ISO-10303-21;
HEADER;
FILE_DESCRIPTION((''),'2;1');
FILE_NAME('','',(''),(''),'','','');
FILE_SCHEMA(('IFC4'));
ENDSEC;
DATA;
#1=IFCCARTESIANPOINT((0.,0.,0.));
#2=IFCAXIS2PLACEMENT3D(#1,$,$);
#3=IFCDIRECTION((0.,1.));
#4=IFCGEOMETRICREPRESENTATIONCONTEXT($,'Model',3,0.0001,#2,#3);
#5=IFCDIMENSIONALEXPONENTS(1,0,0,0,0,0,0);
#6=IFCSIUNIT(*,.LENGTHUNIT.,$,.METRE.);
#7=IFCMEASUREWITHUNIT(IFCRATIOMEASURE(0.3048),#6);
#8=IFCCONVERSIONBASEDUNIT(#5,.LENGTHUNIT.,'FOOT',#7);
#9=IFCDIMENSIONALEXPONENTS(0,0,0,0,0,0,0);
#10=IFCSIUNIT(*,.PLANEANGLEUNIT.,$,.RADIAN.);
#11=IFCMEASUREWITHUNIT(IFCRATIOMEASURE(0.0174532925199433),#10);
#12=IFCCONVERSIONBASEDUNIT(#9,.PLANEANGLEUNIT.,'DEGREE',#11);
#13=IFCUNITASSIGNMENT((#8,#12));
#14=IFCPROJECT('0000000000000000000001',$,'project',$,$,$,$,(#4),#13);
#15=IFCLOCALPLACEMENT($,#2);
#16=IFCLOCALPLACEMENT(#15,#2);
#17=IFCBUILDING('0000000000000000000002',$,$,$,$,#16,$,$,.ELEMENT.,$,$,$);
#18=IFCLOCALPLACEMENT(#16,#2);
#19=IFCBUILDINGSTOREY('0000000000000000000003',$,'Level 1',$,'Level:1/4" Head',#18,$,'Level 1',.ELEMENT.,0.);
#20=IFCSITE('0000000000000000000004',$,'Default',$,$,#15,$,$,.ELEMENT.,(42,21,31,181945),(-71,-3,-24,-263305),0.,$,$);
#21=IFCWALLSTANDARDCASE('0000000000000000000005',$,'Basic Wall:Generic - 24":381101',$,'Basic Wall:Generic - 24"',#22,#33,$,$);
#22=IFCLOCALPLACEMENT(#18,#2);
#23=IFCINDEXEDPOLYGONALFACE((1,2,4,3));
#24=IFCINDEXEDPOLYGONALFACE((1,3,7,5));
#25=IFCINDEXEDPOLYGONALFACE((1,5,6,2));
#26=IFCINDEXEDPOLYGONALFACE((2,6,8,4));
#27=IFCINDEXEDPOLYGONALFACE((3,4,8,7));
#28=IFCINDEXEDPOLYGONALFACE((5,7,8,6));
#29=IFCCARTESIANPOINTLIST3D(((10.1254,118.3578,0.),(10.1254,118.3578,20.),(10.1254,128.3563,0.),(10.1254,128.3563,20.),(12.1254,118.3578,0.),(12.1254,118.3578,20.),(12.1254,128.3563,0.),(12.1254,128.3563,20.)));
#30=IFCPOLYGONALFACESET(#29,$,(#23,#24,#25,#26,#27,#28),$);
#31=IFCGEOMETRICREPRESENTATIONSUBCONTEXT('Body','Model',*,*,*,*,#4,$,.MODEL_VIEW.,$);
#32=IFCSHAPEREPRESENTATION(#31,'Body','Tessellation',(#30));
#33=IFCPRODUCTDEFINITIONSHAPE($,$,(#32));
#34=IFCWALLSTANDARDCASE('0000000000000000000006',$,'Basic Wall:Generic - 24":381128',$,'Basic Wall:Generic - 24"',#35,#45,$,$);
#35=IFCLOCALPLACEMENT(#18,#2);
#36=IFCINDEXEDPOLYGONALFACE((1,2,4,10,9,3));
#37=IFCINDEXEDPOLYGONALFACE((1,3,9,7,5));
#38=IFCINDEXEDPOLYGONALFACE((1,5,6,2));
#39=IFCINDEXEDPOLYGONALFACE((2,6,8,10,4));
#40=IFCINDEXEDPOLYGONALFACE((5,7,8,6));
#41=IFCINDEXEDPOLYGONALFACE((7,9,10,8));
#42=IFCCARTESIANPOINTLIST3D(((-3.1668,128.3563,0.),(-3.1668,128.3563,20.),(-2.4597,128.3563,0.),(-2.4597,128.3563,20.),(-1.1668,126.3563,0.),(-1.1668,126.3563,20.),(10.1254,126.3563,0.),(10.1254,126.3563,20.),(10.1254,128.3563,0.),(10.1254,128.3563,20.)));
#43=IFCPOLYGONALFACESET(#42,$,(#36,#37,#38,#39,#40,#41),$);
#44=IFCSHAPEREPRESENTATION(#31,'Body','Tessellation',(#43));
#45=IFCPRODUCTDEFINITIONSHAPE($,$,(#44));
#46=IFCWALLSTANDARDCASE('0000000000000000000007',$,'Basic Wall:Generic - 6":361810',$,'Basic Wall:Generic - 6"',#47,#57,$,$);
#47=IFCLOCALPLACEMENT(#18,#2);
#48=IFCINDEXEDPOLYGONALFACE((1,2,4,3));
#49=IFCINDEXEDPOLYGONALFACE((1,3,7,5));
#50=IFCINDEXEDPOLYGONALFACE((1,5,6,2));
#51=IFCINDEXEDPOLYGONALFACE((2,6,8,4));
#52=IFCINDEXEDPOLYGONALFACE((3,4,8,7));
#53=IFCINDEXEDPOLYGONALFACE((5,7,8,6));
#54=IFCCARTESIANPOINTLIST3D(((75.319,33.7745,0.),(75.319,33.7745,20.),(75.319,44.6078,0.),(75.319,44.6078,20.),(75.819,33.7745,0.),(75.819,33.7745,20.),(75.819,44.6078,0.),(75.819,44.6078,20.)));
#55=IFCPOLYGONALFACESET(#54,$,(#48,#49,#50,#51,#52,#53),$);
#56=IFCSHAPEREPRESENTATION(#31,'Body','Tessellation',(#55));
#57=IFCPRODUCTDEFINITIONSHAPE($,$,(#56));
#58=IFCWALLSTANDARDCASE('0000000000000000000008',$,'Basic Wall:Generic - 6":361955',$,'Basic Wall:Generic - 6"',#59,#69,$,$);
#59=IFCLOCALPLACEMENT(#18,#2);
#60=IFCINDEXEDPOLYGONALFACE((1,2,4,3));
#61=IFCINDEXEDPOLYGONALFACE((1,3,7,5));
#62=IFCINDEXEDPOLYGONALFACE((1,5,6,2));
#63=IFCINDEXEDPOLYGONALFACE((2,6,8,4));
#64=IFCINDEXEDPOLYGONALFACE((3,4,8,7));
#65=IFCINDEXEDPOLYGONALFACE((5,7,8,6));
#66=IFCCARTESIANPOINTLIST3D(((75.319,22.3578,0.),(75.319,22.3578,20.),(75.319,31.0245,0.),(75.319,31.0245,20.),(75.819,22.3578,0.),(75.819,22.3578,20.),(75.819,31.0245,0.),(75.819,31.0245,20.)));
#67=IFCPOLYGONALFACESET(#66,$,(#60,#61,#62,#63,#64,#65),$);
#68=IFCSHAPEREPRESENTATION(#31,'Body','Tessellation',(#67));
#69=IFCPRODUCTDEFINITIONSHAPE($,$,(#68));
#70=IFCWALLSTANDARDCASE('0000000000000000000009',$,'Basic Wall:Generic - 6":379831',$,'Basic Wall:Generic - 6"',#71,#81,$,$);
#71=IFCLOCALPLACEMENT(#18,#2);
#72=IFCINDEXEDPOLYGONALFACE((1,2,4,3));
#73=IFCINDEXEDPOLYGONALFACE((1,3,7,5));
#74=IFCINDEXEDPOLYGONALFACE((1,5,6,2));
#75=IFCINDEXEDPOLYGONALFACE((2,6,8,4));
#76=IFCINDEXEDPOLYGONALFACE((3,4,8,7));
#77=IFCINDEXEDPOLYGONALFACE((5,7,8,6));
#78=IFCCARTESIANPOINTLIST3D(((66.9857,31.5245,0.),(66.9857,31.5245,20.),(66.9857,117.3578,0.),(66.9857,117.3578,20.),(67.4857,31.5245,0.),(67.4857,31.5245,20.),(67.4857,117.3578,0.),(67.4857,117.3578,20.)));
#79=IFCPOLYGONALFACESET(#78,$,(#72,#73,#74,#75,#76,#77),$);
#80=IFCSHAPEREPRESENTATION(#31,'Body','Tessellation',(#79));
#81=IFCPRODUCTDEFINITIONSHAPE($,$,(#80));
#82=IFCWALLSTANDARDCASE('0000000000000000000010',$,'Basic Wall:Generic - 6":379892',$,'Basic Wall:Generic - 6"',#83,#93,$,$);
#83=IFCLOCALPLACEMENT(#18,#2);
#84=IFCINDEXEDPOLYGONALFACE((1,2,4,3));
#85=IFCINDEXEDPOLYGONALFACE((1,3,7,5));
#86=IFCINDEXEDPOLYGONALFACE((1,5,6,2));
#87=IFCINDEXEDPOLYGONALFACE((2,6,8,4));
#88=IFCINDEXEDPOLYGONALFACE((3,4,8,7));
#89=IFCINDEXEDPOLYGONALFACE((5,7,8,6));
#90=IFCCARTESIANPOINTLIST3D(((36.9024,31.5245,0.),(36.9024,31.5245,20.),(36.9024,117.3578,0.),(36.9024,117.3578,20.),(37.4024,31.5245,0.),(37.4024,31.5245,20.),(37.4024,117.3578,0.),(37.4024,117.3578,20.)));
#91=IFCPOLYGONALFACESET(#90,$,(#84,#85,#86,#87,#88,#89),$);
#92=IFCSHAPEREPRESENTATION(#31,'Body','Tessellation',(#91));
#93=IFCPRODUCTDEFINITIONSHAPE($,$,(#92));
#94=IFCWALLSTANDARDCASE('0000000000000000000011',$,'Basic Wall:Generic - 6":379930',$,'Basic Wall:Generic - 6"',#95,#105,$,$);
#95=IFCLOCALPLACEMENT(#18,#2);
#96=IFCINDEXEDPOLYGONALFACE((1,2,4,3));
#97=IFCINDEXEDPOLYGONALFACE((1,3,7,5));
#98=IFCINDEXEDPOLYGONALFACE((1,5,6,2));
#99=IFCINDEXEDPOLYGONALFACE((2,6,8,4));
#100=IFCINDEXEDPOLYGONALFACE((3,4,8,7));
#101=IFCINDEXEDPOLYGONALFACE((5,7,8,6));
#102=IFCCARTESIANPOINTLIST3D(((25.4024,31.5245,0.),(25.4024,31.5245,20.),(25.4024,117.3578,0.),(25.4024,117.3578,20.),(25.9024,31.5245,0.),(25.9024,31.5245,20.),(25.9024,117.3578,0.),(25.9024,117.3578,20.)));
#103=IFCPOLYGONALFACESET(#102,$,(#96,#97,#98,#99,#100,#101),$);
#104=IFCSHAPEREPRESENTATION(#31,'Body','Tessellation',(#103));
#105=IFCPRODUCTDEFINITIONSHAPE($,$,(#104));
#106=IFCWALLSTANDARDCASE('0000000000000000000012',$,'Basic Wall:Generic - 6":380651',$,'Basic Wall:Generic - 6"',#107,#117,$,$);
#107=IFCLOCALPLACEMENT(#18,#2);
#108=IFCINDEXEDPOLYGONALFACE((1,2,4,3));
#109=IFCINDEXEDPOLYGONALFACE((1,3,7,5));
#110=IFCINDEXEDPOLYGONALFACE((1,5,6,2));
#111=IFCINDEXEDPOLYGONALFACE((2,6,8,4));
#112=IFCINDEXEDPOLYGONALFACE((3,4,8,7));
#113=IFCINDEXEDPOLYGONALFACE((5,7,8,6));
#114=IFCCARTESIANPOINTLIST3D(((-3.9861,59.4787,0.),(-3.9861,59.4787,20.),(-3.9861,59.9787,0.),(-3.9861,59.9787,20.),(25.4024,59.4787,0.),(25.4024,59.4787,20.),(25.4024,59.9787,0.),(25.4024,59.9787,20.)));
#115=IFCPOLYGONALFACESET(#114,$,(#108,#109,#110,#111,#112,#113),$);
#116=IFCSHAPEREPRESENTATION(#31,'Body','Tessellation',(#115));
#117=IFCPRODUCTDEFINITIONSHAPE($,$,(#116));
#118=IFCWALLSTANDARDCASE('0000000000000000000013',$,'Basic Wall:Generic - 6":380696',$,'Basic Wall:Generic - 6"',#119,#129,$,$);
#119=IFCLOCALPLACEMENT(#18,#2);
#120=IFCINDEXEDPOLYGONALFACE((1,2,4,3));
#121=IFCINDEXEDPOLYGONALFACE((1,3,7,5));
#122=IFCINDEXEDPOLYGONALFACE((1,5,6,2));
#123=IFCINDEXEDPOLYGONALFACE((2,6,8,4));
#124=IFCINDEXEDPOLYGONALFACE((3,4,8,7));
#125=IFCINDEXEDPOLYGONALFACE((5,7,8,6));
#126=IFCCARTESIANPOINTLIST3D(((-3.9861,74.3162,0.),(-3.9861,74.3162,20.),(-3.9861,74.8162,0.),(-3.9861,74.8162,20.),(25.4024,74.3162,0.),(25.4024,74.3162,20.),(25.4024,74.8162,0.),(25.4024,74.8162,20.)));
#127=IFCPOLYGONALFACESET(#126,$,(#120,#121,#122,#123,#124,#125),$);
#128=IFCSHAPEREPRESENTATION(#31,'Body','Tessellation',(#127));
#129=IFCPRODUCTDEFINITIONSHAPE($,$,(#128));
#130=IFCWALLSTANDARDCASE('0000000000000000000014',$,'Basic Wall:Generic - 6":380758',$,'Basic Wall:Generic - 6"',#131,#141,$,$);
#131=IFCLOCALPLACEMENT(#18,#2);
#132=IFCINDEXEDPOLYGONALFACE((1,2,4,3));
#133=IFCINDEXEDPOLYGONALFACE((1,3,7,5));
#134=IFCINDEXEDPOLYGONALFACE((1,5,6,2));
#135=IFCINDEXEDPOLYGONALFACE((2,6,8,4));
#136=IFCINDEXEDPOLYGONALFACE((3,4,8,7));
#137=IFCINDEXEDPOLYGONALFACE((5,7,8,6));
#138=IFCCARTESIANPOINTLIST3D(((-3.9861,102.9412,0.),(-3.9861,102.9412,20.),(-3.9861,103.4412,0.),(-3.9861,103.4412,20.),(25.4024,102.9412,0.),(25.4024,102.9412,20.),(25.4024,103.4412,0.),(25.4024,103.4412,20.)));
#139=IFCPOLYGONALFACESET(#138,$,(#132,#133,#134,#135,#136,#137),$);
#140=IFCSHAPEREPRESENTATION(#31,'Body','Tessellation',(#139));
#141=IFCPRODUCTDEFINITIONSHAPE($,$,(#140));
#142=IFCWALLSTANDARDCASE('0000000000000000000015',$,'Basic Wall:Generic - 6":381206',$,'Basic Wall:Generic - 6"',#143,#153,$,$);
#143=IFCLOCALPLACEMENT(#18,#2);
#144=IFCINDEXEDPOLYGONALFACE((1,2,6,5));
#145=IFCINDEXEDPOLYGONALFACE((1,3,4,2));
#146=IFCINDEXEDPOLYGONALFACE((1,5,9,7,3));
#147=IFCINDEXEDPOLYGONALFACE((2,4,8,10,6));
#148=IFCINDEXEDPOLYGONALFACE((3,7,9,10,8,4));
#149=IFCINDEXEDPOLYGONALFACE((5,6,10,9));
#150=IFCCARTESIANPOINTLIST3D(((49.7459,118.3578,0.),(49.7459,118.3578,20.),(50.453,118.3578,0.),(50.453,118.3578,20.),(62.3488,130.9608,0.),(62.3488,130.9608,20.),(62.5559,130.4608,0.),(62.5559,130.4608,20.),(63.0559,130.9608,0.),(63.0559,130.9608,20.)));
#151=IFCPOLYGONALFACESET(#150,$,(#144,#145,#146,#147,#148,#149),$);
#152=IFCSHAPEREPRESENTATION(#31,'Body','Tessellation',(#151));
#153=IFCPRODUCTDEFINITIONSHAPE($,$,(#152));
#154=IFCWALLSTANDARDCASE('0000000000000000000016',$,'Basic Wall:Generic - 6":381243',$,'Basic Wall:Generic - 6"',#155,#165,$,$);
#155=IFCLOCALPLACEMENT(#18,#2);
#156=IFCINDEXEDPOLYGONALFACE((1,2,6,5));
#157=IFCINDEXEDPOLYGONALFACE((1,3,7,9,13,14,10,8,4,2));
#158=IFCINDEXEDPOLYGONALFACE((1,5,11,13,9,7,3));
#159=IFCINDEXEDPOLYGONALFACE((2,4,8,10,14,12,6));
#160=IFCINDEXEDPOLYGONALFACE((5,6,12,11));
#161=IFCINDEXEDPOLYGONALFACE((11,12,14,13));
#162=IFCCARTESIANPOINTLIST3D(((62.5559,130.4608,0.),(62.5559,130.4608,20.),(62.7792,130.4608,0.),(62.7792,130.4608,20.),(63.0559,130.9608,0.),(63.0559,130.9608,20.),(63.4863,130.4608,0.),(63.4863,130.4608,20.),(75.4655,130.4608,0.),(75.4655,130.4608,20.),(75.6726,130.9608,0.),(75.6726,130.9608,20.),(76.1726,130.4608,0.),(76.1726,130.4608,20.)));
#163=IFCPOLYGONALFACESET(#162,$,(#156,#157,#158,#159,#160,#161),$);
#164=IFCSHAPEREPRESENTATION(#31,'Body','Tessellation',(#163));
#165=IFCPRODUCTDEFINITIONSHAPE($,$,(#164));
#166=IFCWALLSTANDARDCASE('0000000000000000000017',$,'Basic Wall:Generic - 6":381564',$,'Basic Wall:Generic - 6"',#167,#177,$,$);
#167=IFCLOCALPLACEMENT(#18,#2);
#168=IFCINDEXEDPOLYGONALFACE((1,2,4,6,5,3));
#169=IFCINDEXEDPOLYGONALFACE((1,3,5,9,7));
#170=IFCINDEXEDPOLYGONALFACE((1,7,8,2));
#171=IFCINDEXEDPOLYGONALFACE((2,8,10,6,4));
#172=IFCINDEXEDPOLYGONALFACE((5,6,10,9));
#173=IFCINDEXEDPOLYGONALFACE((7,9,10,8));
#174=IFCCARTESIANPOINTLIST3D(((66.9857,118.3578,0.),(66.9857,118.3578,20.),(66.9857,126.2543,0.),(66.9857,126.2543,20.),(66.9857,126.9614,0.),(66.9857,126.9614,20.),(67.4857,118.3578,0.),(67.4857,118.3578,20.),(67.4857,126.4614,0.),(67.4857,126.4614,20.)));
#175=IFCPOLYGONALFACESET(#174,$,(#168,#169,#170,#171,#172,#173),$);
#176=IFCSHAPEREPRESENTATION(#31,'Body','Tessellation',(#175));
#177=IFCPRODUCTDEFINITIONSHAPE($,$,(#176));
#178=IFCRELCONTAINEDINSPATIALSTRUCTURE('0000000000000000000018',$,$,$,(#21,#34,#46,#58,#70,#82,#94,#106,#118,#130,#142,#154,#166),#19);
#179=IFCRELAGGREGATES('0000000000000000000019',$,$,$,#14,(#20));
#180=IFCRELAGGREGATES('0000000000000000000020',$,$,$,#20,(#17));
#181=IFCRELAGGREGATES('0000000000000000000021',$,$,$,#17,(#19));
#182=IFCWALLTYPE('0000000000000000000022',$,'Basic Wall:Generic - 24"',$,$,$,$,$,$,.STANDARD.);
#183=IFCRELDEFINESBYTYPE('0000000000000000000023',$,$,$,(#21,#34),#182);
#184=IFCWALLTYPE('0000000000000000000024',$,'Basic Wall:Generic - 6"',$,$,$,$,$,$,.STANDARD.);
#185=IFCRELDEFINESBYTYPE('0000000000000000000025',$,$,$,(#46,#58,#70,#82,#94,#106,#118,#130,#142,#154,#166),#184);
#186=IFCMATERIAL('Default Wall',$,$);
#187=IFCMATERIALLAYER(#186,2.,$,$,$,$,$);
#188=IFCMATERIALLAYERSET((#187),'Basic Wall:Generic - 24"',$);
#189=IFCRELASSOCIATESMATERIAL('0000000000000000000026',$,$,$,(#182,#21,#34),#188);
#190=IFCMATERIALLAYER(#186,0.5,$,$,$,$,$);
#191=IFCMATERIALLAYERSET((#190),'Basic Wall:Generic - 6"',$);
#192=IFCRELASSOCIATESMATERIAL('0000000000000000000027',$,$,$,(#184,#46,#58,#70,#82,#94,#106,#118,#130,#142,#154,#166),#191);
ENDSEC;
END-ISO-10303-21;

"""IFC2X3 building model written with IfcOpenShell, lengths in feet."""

from ifc_helpers import new_model, entity, si_unit, converted_unit, direction, frame, frame_2d, origin, place, context, subcontext, project, spatial, polyline, rectangle, outline, extrude, material, layer, layer_set, layer_usage, type_object, element, save


model = new_model("IFC2X3")

# Units and contexts
model_context = context("Model", 3, precision=0.0001, world=origin(), true_north=direction((0.0, 1.0)))
body_context = subcontext(model_context, "Body", "Model", "MODEL_VIEW")
ifc_project = project(units=[converted_unit("LENGTHUNIT", "FOOT", entity("IfcRatioMeasure", 0.3048), si_unit("LENGTHUNIT", "METRE"), dimensions=[1, 0, 0, 0, 0, 0, 0]), converted_unit("PLANEANGLEUNIT", "DEGREE", entity("IfcRatioMeasure", 0.0174532925199433), si_unit("PLANEANGLEUNIT", "RADIAN"), dimensions=[0, 0, 0, 0, 0, 0, 0])], contexts=[model_context])

# Site, building, storey
site_placement = place(None, origin())
site = spatial("IfcSite", under=ifc_project, at=site_placement, Name="Default", CompositionType="ELEMENT", RefLatitude=(42, 21, 31, 181945), RefLongitude=(-71, -3, -24, -263305), RefElevation=0.0)
building_placement = place(site_placement, origin())
building = spatial("IfcBuilding", under=site, at=building_placement, CompositionType="ELEMENT")
storey_placement = place(building_placement, origin())
storey = spatial("IfcBuildingStorey", under=building, at=storey_placement, Name="Level 1", ObjectType="Level:1/4\" Head", LongName="Level 1", CompositionType="ELEMENT", Elevation=0.0)

# Walls
ifc_material = material(Name="Default Wall")
ifc_layer_1 = layer(ifc_material, 2.0)
ifc_layer_set_1 = layer_set([ifc_layer_1], Name="Basic Wall:Generic - 24\"")
ifc_layer_usage_1 = layer_usage(ifc_layer_set_1, "AXIS2", "NEGATIVE", 1.0)
wall_type_1 = type_object("IfcWallType", Name="Basic Wall:Generic - 24\"", PredefinedType="STANDARD", material=ifc_layer_set_1)
wall_1_placement = place(storey_placement, frame((11.1254, 118.3578, 0.0), z_axis=(0.0, 0.0, 1.0), x_axis=(0.0, 1.0, 0.0)))
element("IfcWallStandardCase", 1, at=wall_1_placement, inside=storey, type_object=wall_type_1, material=ifc_layer_usage_1, Name="Basic Wall:Generic - 24\":381101", ObjectType="Basic Wall:Generic - 24\"", context=body_context, shape_type="SweptSolid", body=[
    extrude(rectangle(XDim=9.9985, YDim=2.0, at=frame_2d((4.9992, 0.0), x_axis=(-1.0, 0.0))), origin(), (0.0, 0.0, 1.0), 20.0),
])
ifc_layer_usage_2 = layer_usage(ifc_layer_set_1, "AXIS2", "NEGATIVE", 1.0)
wall_2_placement = place(storey_placement, frame((10.1254, 127.3563, 0.0), z_axis=(0.0, 0.0, 1.0), x_axis=(-1.0, 0.0, 0.0)))
element("IfcWallStandardCase", 2, at=wall_2_placement, inside=storey, type_object=wall_type_1, material=ifc_layer_usage_2, Name="Basic Wall:Generic - 24\":381128", ObjectType="Basic Wall:Generic - 24\"", context=body_context, shape_type="SweptSolid", body=[
    extrude(outline(polyline([(13.2922, -1.0), (11.2922, 1.0), (0.0, 1.0), (0.0, -1.0), (12.5851, -1.0), (13.2922, -1.0)])), origin(), (0.0, 0.0, 1.0), 20.0),
])
ifc_layer_2 = layer(ifc_material, 0.5)
ifc_layer_set_2 = layer_set([ifc_layer_2], Name="Basic Wall:Generic - 6\"")
ifc_layer_usage_3 = layer_usage(ifc_layer_set_2, "AXIS2", "NEGATIVE", 0.25)
wall_type_2 = type_object("IfcWallType", Name="Basic Wall:Generic - 6\"", PredefinedType="STANDARD", material=ifc_layer_set_2)
wall_3_placement = place(storey_placement, frame((75.569, 33.7745, 0.0), z_axis=(0.0, 0.0, 1.0), x_axis=(0.0, 1.0, 0.0)))
element("IfcWallStandardCase", 3, at=wall_3_placement, inside=storey, type_object=wall_type_2, material=ifc_layer_usage_3, Name="Basic Wall:Generic - 6\":361810", ObjectType="Basic Wall:Generic - 6\"", context=body_context, shape_type="SweptSolid", body=[
    extrude(rectangle(XDim=10.8333, YDim=0.5, at=frame_2d((5.4167, 0.0), x_axis=(-1.0, 0.0))), origin(), (0.0, 0.0, 1.0), 20.0),
])
ifc_layer_usage_4 = layer_usage(ifc_layer_set_2, "AXIS2", "NEGATIVE", 0.25)
wall_4_placement = place(storey_placement, frame((75.569, 31.0245, 0.0), z_axis=(0.0, 0.0, 1.0), x_axis=(0.0, -1.0, 0.0)))
element("IfcWallStandardCase", 4, at=wall_4_placement, inside=storey, type_object=wall_type_2, material=ifc_layer_usage_4, Name="Basic Wall:Generic - 6\":361955", ObjectType="Basic Wall:Generic - 6\"", context=body_context, shape_type="SweptSolid", body=[
    extrude(rectangle(XDim=8.6667, YDim=0.5, at=frame_2d((4.3333, 0.0), x_axis=(-1.0, 0.0))), origin(), (0.0, 0.0, 1.0), 20.0),
])
ifc_layer_usage_5 = layer_usage(ifc_layer_set_2, "AXIS2", "NEGATIVE", 0.25)
wall_5_placement = place(storey_placement, frame((67.2357, 31.5245, 0.0), z_axis=(0.0, 0.0, 1.0), x_axis=(0.0, 1.0, 0.0)))
element("IfcWallStandardCase", 5, at=wall_5_placement, inside=storey, type_object=wall_type_2, material=ifc_layer_usage_5, Name="Basic Wall:Generic - 6\":379831", ObjectType="Basic Wall:Generic - 6\"", context=body_context, shape_type="SweptSolid", body=[
    extrude(rectangle(XDim=85.8333, YDim=0.5, at=frame_2d((42.9167, 0.0), x_axis=(-1.0, 0.0))), origin(), (0.0, 0.0, 1.0), 20.0),
])
ifc_layer_usage_6 = layer_usage(ifc_layer_set_2, "AXIS2", "NEGATIVE", 0.25)
wall_6_placement = place(storey_placement, frame((37.1524, 117.3578, 0.0), z_axis=(0.0, 0.0, 1.0), x_axis=(0.0, -1.0, 0.0)))
element("IfcWallStandardCase", 6, at=wall_6_placement, inside=storey, type_object=wall_type_2, material=ifc_layer_usage_6, Name="Basic Wall:Generic - 6\":379892", ObjectType="Basic Wall:Generic - 6\"", context=body_context, shape_type="SweptSolid", body=[
    extrude(rectangle(XDim=85.8333, YDim=0.5, at=frame_2d((42.9167, 0.0), x_axis=(-1.0, 0.0))), origin(), (0.0, 0.0, 1.0), 20.0),
])
ifc_layer_usage_7 = layer_usage(ifc_layer_set_2, "AXIS2", "NEGATIVE", 0.25)
wall_7_placement = place(storey_placement, frame((25.6524, 31.5245, 0.0), z_axis=(0.0, 0.0, 1.0), x_axis=(0.0, 1.0, 0.0)))
element("IfcWallStandardCase", 7, at=wall_7_placement, inside=storey, type_object=wall_type_2, material=ifc_layer_usage_7, Name="Basic Wall:Generic - 6\":379930", ObjectType="Basic Wall:Generic - 6\"", context=body_context, shape_type="SweptSolid", body=[
    extrude(rectangle(XDim=85.8333, YDim=0.5, at=frame_2d((42.9167, 0.0), x_axis=(-1.0, 0.0))), origin(), (0.0, 0.0, 1.0), 20.0),
])
ifc_layer_usage_8 = layer_usage(ifc_layer_set_2, "AXIS2", "NEGATIVE", 0.25)
wall_8_placement = place(storey_placement, frame((25.4024, 59.7287, 0.0), z_axis=(0.0, 0.0, 1.0), x_axis=(-1.0, 0.0, 0.0)))
element("IfcWallStandardCase", 8, at=wall_8_placement, inside=storey, type_object=wall_type_2, material=ifc_layer_usage_8, Name="Basic Wall:Generic - 6\":380651", ObjectType="Basic Wall:Generic - 6\"", context=body_context, shape_type="SweptSolid", body=[
    extrude(rectangle(XDim=29.3884, YDim=0.5, at=frame_2d((14.6942, 0.0), x_axis=(-1.0, 0.0))), origin(), (0.0, 0.0, 1.0), 20.0),
])
ifc_layer_usage_9 = layer_usage(ifc_layer_set_2, "AXIS2", "NEGATIVE", 0.25)
wall_9_placement = place(storey_placement, frame((25.4024, 74.5662, 0.0), z_axis=(0.0, 0.0, 1.0), x_axis=(-1.0, 0.0, 0.0)))
element("IfcWallStandardCase", 9, at=wall_9_placement, inside=storey, type_object=wall_type_2, material=ifc_layer_usage_9, Name="Basic Wall:Generic - 6\":380696", ObjectType="Basic Wall:Generic - 6\"", context=body_context, shape_type="SweptSolid", body=[
    extrude(rectangle(XDim=29.3884, YDim=0.5, at=frame_2d((14.6942, 0.0), x_axis=(-1.0, 0.0))), origin(), (0.0, 0.0, 1.0), 20.0),
])
ifc_layer_usage_10 = layer_usage(ifc_layer_set_2, "AXIS2", "NEGATIVE", 0.25)
wall_10_placement = place(storey_placement, frame((25.4024, 103.1912, 0.0), z_axis=(0.0, 0.0, 1.0), x_axis=(-1.0, 0.0, 0.0)))
element("IfcWallStandardCase", 10, at=wall_10_placement, inside=storey, type_object=wall_type_2, material=ifc_layer_usage_10, Name="Basic Wall:Generic - 6\":380758", ObjectType="Basic Wall:Generic - 6\"", context=body_context, shape_type="SweptSolid", body=[
    extrude(rectangle(XDim=29.3884, YDim=0.5, at=frame_2d((14.6942, 0.0), x_axis=(-1.0, 0.0))), origin(), (0.0, 0.0, 1.0), 20.0),
])
ifc_layer_usage_11 = layer_usage(ifc_layer_set_2, "AXIS2", "NEGATIVE", 0.25)
wall_11_placement = place(storey_placement, frame((49.9227, 118.1811, 0.0), z_axis=(0.0, 0.0, 1.0), x_axis=(0.707107, 0.707107, 0.0)))
element("IfcWallStandardCase", 11, at=wall_11_placement, inside=storey, type_object=wall_type_2, material=ifc_layer_usage_11, Name="Basic Wall:Generic - 6\":381206", ObjectType="Basic Wall:Generic - 6\"", context=body_context, shape_type="SweptSolid", body=[
    extrude(outline(polyline([(18.3233, -0.25), (17.8233, 0.25), (0.0, 0.25), (0.5, -0.25), (17.6162, -0.25), (18.3233, -0.25)])), origin(), (0.0, 0.0, 1.0), 20.0),
])
ifc_layer_usage_12 = layer_usage(ifc_layer_set_2, "AXIS2", "NEGATIVE", 0.25)
wall_12_placement = place(storey_placement, frame((62.5559, 130.7108, 0.0)))
element("IfcWallStandardCase", 12, at=wall_12_placement, inside=storey, type_object=wall_type_2, material=ifc_layer_usage_12, Name="Basic Wall:Generic - 6\":381243", ObjectType="Basic Wall:Generic - 6\"", context=body_context, shape_type="SweptSolid", body=[
    extrude(outline(polyline([(13.6166, -0.25), (13.1166, 0.25), (0.5, 0.25), (0.0, -0.25), (0.2233, -0.25), (0.9304, -0.25), (12.9095, -0.25), (13.6166, -0.25)])), origin(), (0.0, 0.0, 1.0), 20.0),
])
ifc_layer_usage_13 = layer_usage(ifc_layer_set_2, "AXIS2", "NEGATIVE", 0.25)
wall_13_placement = place(storey_placement, frame((67.2357, 118.3578, 0.0), z_axis=(0.0, 0.0, 1.0), x_axis=(0.0, 1.0, 0.0)))
element("IfcWallStandardCase", 13, at=wall_13_placement, inside=storey, type_object=wall_type_2, material=ifc_layer_usage_13, Name="Basic Wall:Generic - 6\":381564", ObjectType="Basic Wall:Generic - 6\"", context=body_context, shape_type="SweptSolid", body=[
    extrude(outline(polyline([(8.1036, -0.25), (8.6036, 0.25), (7.8964, 0.25), (0.0, 0.25), (0.0, -0.25), (8.1036, -0.25)])), origin(), (0.0, 0.0, 1.0), 20.0),
])

save(model, "model.ifc")
